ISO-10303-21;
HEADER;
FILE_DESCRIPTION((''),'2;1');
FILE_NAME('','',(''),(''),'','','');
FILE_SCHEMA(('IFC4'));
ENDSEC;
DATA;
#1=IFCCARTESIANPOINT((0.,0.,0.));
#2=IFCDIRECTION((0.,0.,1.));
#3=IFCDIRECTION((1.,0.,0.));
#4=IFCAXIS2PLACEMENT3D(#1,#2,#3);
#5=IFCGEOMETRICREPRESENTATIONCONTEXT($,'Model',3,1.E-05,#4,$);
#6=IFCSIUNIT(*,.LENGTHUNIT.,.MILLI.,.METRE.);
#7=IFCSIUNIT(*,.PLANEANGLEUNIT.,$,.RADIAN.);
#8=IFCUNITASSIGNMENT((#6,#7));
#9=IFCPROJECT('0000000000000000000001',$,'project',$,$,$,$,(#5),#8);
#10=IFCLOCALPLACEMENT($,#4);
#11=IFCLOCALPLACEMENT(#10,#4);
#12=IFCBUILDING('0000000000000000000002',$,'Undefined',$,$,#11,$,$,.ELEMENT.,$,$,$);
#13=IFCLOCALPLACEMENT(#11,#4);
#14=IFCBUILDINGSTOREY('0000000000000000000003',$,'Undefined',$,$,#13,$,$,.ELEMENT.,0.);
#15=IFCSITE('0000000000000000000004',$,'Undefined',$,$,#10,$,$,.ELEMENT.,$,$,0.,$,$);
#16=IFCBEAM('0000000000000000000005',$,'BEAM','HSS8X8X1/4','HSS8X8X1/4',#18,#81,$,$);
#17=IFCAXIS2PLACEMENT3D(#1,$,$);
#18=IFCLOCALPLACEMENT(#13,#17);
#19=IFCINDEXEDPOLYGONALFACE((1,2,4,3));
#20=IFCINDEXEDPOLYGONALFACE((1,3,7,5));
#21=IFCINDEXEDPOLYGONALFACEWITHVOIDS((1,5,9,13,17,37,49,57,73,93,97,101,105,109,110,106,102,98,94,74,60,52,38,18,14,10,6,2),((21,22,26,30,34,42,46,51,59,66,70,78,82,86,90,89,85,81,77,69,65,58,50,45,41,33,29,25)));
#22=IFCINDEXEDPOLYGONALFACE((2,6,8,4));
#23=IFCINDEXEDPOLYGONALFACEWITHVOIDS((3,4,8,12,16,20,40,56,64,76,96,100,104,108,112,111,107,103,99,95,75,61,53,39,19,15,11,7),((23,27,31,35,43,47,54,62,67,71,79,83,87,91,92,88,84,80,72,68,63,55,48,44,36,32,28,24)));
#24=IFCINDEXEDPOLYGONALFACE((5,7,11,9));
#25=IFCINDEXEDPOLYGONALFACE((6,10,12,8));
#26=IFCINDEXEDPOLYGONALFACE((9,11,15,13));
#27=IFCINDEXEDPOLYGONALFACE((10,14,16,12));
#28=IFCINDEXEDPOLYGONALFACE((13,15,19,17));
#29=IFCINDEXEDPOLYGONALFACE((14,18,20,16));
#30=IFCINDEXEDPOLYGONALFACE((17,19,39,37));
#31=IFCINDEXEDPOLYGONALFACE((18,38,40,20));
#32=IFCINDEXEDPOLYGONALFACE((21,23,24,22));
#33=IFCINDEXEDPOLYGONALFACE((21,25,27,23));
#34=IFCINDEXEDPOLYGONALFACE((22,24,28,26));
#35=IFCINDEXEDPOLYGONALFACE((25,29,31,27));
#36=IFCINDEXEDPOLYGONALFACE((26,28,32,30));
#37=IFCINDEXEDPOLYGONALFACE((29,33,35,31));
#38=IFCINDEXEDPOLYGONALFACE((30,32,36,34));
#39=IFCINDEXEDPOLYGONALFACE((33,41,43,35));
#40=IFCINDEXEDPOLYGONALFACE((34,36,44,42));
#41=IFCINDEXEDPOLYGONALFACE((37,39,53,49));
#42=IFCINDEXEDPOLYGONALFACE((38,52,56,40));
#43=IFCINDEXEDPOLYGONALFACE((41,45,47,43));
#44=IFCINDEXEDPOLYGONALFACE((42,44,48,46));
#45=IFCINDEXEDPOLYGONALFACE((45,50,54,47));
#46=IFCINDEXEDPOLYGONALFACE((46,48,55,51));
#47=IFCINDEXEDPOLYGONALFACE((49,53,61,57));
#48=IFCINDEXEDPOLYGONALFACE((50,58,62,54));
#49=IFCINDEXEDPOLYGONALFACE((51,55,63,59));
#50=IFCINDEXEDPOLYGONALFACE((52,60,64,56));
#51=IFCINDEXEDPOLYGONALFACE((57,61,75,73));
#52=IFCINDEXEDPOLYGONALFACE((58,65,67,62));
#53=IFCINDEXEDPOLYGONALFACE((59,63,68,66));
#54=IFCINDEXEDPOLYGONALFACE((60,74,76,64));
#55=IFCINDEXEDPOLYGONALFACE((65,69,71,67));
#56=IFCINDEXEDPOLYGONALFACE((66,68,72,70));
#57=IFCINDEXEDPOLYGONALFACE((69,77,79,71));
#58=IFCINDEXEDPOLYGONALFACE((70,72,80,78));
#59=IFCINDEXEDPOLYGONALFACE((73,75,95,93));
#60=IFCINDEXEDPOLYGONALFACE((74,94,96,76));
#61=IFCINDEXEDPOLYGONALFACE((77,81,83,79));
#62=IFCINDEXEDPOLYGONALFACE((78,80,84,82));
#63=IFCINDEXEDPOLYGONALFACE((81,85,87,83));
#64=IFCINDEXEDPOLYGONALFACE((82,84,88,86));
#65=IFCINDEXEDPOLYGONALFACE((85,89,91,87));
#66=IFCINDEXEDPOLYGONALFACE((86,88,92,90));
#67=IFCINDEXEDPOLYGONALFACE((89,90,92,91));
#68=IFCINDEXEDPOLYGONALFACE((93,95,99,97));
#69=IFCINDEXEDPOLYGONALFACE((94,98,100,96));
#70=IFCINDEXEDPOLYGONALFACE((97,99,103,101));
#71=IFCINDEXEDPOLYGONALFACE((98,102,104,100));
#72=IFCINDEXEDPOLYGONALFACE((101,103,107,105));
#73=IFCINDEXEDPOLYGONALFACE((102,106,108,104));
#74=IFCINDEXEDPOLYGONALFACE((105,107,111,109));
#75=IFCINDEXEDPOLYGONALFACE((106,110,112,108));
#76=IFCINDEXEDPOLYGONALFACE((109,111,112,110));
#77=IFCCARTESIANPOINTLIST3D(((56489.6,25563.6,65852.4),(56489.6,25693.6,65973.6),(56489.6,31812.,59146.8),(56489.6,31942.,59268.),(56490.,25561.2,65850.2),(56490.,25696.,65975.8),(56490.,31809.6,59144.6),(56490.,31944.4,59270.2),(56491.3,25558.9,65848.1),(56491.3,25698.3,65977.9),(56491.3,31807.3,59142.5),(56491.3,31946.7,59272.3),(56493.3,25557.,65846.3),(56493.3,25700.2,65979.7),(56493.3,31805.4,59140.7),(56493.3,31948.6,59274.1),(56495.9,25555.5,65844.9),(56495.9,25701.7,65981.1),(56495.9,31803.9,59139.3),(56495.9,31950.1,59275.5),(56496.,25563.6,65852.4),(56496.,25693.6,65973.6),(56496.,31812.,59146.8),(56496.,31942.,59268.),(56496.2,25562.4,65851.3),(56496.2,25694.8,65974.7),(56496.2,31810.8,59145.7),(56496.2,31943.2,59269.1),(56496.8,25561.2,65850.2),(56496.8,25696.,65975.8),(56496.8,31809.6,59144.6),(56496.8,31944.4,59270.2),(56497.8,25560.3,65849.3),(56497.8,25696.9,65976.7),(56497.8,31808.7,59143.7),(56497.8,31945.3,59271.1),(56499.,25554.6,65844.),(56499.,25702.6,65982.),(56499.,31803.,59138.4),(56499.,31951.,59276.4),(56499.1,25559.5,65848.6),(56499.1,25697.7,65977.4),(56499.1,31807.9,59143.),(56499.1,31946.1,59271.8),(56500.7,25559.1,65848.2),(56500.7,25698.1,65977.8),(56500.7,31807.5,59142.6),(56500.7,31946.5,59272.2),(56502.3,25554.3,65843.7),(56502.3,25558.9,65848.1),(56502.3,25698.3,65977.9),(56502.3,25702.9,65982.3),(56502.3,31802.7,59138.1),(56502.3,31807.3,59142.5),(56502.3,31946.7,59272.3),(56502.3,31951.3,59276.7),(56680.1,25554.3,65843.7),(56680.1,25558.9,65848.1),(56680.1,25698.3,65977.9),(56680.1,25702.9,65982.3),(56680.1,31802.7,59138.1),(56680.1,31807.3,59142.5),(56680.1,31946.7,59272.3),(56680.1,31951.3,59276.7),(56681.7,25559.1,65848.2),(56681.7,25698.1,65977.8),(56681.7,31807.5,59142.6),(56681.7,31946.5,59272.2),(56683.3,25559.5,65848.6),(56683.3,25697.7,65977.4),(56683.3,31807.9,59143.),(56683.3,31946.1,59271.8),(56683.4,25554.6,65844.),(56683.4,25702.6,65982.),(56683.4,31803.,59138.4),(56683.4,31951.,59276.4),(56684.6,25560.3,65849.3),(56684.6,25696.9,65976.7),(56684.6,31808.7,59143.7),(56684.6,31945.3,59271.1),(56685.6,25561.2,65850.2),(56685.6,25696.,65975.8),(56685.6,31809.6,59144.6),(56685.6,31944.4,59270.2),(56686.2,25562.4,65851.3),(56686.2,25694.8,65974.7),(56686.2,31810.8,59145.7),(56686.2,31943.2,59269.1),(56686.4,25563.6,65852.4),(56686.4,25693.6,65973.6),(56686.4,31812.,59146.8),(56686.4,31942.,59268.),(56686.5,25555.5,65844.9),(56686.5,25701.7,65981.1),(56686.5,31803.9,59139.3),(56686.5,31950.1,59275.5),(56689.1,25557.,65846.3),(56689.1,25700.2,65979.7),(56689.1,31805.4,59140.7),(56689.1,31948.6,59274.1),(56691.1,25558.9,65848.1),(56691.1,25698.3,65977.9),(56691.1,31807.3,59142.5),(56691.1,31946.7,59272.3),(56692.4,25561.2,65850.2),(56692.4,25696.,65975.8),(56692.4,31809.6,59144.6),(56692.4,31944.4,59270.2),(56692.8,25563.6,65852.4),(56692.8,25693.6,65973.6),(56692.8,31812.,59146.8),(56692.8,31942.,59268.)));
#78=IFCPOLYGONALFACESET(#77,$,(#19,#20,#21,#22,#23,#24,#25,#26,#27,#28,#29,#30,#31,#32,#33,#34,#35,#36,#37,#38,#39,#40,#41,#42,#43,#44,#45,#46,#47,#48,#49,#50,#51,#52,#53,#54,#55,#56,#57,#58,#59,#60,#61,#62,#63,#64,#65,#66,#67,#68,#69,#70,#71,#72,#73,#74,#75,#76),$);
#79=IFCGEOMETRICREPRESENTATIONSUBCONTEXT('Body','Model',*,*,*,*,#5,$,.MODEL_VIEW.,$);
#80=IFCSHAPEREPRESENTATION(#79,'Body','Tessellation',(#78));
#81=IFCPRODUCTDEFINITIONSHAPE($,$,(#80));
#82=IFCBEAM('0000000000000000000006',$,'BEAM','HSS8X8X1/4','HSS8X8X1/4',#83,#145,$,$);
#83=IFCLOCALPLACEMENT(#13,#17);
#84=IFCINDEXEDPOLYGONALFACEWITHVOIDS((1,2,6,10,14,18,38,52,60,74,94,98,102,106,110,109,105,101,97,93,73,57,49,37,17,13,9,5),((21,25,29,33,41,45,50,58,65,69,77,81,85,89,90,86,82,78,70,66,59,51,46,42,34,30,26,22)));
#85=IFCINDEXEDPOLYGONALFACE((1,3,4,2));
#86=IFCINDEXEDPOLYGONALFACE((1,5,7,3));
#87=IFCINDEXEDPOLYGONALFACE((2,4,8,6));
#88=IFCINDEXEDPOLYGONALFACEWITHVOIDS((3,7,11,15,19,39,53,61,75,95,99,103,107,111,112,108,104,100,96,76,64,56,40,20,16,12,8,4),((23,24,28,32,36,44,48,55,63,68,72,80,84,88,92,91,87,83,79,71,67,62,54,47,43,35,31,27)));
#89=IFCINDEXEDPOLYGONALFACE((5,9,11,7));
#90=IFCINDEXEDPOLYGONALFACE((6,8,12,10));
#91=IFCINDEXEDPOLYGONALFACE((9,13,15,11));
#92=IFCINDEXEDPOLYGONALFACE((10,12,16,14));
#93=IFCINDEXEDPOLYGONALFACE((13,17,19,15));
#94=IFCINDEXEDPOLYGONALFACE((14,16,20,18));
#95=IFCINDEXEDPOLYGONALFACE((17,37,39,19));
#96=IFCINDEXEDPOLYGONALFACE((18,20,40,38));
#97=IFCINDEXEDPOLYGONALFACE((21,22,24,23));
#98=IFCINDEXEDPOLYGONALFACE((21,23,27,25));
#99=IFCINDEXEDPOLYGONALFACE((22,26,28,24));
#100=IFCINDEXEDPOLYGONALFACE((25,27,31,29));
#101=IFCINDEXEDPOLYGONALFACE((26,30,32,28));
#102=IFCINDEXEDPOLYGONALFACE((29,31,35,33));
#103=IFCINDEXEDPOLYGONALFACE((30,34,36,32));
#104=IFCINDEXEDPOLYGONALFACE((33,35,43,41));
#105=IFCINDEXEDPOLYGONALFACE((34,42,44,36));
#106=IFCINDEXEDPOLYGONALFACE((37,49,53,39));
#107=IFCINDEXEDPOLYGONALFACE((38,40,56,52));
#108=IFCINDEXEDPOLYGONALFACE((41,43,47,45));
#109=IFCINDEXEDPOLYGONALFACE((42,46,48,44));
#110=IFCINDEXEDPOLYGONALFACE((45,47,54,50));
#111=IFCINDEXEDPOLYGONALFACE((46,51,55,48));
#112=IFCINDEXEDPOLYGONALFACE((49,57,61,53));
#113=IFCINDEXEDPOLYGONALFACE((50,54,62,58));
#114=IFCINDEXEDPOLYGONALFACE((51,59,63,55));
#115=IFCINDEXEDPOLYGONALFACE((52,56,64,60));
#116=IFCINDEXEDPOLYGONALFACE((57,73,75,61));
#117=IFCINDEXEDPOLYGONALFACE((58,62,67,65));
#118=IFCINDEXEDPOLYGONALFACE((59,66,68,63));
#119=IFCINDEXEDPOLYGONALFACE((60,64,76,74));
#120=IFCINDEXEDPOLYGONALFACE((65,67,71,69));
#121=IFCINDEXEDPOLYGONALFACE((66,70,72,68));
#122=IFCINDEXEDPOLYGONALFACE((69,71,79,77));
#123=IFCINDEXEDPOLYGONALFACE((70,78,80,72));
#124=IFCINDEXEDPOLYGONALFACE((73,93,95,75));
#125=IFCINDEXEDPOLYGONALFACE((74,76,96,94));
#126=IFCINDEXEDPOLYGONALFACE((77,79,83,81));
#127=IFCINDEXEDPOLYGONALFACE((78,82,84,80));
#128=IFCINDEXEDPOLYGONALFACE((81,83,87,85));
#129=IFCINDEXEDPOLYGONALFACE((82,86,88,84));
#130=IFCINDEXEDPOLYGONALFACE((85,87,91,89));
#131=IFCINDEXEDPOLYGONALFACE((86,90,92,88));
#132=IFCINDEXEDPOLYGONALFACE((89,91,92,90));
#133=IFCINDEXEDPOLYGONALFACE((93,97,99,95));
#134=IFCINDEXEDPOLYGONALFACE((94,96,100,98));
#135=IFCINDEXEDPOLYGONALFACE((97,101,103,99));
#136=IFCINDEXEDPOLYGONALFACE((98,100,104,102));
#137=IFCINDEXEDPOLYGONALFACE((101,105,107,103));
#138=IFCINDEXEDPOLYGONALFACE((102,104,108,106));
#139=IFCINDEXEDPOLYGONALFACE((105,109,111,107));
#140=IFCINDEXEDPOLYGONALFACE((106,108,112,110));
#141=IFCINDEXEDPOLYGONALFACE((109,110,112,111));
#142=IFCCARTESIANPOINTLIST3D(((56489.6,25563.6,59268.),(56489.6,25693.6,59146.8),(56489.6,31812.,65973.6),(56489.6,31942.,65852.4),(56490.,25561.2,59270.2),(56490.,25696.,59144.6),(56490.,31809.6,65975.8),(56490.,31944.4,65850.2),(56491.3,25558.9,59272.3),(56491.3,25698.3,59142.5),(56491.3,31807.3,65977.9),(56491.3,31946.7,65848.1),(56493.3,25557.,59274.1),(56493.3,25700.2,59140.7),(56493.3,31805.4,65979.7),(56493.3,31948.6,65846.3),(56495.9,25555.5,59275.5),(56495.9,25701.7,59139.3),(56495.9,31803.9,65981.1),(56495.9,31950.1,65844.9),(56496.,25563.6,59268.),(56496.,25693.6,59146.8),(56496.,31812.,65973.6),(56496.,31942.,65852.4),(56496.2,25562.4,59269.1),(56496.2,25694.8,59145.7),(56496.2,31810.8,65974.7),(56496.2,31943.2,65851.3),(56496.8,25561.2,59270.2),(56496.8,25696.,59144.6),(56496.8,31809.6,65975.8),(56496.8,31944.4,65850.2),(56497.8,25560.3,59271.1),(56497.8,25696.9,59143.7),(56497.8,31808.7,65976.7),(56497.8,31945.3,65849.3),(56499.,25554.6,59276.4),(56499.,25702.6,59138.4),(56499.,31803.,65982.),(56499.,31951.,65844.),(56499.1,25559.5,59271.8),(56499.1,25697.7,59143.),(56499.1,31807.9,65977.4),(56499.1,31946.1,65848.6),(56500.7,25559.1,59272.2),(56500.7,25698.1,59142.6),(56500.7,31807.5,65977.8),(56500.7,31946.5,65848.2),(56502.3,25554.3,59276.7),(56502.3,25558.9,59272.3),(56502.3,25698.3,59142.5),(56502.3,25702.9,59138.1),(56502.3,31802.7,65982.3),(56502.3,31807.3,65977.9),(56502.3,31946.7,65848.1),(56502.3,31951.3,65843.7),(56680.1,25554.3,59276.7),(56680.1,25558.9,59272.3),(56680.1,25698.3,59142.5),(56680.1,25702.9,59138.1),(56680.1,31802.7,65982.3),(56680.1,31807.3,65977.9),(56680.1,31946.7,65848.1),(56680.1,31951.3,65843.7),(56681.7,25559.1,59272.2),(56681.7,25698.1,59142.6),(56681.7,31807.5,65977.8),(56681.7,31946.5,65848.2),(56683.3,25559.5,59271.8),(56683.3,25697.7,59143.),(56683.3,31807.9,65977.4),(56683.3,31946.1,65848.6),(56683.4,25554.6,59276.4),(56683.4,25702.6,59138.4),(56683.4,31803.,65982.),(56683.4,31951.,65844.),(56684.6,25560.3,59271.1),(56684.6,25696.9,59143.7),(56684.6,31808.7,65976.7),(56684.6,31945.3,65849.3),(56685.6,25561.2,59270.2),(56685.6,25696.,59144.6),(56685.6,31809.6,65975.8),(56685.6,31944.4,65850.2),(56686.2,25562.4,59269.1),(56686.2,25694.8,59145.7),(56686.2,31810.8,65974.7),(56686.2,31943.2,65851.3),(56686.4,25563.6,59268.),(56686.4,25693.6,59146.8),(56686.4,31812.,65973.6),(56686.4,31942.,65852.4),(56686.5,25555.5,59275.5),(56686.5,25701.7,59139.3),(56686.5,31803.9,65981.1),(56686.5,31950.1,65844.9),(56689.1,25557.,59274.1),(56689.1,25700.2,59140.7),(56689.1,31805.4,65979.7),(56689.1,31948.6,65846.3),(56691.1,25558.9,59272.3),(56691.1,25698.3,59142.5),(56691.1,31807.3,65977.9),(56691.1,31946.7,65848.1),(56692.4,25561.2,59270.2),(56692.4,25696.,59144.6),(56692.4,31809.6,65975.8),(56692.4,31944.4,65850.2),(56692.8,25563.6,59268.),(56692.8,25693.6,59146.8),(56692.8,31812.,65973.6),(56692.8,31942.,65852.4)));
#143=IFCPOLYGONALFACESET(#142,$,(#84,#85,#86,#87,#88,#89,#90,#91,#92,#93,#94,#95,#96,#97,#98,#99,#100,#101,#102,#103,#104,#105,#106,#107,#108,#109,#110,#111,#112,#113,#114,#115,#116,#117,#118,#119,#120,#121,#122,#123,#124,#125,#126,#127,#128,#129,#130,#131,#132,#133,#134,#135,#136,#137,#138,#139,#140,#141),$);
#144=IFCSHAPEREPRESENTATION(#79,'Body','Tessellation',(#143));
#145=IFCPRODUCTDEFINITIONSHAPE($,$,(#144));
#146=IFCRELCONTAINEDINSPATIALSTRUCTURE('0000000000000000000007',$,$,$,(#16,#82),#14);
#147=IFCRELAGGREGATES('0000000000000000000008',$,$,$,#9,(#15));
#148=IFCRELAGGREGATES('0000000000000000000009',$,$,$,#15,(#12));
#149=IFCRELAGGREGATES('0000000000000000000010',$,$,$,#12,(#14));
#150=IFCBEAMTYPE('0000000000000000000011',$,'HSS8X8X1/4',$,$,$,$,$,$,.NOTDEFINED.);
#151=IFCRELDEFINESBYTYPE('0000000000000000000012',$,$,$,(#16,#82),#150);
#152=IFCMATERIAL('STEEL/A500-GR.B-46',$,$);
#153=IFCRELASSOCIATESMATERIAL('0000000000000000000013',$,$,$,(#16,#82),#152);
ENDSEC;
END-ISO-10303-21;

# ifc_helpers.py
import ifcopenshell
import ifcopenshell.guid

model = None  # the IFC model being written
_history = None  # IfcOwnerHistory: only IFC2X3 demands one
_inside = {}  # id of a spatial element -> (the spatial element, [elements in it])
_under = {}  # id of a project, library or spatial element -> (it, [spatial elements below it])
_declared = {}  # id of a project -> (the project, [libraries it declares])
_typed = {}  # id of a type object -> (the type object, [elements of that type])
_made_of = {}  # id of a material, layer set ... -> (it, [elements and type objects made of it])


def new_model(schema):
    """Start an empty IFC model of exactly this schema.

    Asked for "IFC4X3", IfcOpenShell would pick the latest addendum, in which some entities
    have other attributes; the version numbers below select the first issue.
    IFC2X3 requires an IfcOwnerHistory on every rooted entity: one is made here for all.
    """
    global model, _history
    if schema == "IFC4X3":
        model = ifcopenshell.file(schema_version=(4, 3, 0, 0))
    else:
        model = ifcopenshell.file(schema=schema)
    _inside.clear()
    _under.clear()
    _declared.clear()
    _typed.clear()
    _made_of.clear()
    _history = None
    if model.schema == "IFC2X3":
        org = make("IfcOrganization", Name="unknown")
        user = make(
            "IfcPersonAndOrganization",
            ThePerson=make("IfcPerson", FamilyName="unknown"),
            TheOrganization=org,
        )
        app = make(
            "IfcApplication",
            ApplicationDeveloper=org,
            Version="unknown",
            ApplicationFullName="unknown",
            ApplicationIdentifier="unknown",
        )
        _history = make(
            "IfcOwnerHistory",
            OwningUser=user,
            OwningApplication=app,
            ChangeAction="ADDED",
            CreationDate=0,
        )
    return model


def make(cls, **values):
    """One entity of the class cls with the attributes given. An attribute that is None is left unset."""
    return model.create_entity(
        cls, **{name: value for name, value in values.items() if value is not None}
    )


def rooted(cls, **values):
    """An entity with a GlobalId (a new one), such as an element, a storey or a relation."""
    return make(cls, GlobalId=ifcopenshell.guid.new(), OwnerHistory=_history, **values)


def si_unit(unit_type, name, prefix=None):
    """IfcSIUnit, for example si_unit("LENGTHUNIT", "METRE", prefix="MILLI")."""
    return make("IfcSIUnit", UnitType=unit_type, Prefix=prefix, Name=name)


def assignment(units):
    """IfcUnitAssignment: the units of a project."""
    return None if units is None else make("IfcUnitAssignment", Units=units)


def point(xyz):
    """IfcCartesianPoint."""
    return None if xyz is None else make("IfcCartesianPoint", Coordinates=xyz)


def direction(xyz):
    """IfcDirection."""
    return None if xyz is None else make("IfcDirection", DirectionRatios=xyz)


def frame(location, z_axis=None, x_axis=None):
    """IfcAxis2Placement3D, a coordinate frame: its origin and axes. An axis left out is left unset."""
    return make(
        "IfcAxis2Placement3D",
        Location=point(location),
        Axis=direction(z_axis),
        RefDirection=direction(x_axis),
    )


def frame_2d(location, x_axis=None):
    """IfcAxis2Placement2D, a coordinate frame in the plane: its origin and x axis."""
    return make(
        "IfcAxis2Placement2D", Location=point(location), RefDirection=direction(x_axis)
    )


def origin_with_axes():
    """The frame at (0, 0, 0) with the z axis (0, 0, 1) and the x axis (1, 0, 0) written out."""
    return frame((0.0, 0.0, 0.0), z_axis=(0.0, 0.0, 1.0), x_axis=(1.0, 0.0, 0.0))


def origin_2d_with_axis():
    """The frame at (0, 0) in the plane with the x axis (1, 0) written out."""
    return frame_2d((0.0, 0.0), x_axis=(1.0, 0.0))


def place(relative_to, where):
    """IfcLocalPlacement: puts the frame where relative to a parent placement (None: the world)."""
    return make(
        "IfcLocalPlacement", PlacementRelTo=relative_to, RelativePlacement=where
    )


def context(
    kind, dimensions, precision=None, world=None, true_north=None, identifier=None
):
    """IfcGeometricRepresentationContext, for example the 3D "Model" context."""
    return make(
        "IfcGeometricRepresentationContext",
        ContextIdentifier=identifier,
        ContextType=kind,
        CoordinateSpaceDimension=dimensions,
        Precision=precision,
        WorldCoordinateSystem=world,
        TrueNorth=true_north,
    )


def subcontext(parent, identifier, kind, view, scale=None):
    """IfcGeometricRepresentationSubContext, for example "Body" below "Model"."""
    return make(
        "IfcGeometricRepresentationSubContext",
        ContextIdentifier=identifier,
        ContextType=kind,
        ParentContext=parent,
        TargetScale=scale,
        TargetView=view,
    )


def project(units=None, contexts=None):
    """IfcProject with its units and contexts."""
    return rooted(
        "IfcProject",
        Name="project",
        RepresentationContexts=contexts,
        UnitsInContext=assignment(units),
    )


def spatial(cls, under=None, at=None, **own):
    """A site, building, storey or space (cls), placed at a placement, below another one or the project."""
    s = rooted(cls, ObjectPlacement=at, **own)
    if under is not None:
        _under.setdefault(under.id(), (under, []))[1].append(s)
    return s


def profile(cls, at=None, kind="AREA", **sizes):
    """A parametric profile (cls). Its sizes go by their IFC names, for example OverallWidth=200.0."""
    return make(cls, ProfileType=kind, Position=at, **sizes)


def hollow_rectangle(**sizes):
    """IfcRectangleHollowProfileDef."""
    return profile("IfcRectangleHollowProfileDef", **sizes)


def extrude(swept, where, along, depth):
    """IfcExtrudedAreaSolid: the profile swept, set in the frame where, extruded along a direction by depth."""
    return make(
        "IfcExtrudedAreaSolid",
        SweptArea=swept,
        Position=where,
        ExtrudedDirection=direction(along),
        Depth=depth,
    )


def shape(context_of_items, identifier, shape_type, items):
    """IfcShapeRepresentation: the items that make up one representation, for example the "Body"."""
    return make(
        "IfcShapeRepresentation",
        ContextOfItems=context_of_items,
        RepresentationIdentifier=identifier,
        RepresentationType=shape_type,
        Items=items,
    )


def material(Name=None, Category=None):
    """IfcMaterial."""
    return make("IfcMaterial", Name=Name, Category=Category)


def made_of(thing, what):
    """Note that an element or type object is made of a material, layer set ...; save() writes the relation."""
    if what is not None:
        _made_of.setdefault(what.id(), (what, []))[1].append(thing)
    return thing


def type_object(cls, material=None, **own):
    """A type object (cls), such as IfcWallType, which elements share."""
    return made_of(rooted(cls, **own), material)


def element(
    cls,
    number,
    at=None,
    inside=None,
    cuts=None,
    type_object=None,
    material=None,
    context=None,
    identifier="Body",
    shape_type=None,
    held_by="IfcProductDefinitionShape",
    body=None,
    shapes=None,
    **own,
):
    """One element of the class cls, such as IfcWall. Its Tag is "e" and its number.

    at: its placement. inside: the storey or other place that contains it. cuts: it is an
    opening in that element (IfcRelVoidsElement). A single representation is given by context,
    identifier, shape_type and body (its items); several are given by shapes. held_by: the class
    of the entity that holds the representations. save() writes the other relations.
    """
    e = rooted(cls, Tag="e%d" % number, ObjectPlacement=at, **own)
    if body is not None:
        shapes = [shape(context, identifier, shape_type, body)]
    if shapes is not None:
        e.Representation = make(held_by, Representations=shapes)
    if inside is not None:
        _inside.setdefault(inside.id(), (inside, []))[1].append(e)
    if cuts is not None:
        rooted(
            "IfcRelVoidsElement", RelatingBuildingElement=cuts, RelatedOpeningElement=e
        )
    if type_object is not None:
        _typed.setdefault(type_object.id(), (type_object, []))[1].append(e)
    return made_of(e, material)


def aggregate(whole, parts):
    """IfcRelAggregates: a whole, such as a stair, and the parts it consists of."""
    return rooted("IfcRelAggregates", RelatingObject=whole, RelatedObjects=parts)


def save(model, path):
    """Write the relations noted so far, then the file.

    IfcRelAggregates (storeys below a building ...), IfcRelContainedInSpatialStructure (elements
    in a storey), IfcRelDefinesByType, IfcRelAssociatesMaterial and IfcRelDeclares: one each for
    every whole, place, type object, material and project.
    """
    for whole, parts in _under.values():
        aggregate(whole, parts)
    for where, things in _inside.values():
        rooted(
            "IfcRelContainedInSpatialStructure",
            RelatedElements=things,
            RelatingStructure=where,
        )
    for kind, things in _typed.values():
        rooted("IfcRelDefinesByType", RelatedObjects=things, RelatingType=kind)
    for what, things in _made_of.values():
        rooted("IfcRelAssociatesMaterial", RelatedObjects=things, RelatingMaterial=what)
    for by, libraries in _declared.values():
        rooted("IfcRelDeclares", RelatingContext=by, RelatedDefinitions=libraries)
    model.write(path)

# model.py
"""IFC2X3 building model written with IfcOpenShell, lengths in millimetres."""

from ifc_helpers import new_model, si_unit, frame, origin_with_axes, origin_2d_with_axis, place, context, subcontext, project, spatial, hollow_rectangle, extrude, material, type_object, element, save


model = new_model("IFC2X3")

# Units and contexts
model_context = context("Model", 3, precision=1e-05, world=origin_with_axes())
body_context = subcontext(model_context, "Body", "Model", "MODEL_VIEW")
ifc_project = project(units=[si_unit("LENGTHUNIT", "METRE", prefix="MILLI"), si_unit("PLANEANGLEUNIT", "RADIAN")], contexts=[model_context])

# Site, building, storey
site_placement = place(None, origin_with_axes())
site = spatial("IfcSite", under=ifc_project, at=site_placement, Name="Undefined", CompositionType="ELEMENT", RefElevation=0.0)
building_placement = place(site_placement, origin_with_axes())
building = spatial("IfcBuilding", under=site, at=building_placement, Name="Undefined", CompositionType="ELEMENT")
storey_placement = place(building_placement, origin_with_axes())
storey = spatial("IfcBuildingStorey", under=building, at=storey_placement, Name="Undefined", CompositionType="ELEMENT", Elevation=0.0)

# Beams
ifc_material_1 = material(Name="STEEL/A500-GR.B-46")
beam_type_1 = type_object("IfcBeamType", Name="HSS8X8X1/4", PredefinedType="NOTDEFINED")
beam_1_placement = place(storey_placement, frame((56591.2, 31877.0, 59207.4), z_axis=(0.0, 0.731608, 0.681726), x_axis=(0.0, -0.681726, 0.731608)))
element("IfcBeam", 1, at=beam_1_placement, inside=storey, type_object=beam_type_1, material=ifc_material_1, Name="BEAM", Description="HSS8X8X1/4", ObjectType="HSS8X8X1/4", context=body_context, shape_type="SweptSolid", body=[
    extrude(hollow_rectangle(XDim=203.2, YDim=203.2, WallThickness=6.3, InnerFilletRadius=6.3, OuterFilletRadius=12.7, at=origin_2d_with_axis()), frame((9165.6, 0.0, 0.0), z_axis=(-1.0, 0.0, 0.0), x_axis=(0.0, -1.0, 0.0)), (0.0, 0.0, 1.0), 9165.6),
])
beam_2_placement = place(storey_placement, frame((56591.2, 25628.6, 59207.4), z_axis=(0.0, -0.731608, 0.681726), x_axis=(0.0, 0.681726, 0.731608)))
element("IfcBeam", 2, at=beam_2_placement, inside=storey, type_object=beam_type_1, material=ifc_material_1, Name="BEAM", Description="HSS8X8X1/4", ObjectType="HSS8X8X1/4", context=body_context, shape_type="SweptSolid", body=[
    extrude(hollow_rectangle(XDim=203.2, YDim=203.2, WallThickness=6.3, InnerFilletRadius=6.3, OuterFilletRadius=12.7, at=origin_2d_with_axis()), frame((9165.6, 0.0, 0.0), z_axis=(-1.0, 0.0, 0.0), x_axis=(0.0, -1.0, 0.0)), (0.0, 0.0, 1.0), 9165.6),
])

save(model, "model.ifc")
